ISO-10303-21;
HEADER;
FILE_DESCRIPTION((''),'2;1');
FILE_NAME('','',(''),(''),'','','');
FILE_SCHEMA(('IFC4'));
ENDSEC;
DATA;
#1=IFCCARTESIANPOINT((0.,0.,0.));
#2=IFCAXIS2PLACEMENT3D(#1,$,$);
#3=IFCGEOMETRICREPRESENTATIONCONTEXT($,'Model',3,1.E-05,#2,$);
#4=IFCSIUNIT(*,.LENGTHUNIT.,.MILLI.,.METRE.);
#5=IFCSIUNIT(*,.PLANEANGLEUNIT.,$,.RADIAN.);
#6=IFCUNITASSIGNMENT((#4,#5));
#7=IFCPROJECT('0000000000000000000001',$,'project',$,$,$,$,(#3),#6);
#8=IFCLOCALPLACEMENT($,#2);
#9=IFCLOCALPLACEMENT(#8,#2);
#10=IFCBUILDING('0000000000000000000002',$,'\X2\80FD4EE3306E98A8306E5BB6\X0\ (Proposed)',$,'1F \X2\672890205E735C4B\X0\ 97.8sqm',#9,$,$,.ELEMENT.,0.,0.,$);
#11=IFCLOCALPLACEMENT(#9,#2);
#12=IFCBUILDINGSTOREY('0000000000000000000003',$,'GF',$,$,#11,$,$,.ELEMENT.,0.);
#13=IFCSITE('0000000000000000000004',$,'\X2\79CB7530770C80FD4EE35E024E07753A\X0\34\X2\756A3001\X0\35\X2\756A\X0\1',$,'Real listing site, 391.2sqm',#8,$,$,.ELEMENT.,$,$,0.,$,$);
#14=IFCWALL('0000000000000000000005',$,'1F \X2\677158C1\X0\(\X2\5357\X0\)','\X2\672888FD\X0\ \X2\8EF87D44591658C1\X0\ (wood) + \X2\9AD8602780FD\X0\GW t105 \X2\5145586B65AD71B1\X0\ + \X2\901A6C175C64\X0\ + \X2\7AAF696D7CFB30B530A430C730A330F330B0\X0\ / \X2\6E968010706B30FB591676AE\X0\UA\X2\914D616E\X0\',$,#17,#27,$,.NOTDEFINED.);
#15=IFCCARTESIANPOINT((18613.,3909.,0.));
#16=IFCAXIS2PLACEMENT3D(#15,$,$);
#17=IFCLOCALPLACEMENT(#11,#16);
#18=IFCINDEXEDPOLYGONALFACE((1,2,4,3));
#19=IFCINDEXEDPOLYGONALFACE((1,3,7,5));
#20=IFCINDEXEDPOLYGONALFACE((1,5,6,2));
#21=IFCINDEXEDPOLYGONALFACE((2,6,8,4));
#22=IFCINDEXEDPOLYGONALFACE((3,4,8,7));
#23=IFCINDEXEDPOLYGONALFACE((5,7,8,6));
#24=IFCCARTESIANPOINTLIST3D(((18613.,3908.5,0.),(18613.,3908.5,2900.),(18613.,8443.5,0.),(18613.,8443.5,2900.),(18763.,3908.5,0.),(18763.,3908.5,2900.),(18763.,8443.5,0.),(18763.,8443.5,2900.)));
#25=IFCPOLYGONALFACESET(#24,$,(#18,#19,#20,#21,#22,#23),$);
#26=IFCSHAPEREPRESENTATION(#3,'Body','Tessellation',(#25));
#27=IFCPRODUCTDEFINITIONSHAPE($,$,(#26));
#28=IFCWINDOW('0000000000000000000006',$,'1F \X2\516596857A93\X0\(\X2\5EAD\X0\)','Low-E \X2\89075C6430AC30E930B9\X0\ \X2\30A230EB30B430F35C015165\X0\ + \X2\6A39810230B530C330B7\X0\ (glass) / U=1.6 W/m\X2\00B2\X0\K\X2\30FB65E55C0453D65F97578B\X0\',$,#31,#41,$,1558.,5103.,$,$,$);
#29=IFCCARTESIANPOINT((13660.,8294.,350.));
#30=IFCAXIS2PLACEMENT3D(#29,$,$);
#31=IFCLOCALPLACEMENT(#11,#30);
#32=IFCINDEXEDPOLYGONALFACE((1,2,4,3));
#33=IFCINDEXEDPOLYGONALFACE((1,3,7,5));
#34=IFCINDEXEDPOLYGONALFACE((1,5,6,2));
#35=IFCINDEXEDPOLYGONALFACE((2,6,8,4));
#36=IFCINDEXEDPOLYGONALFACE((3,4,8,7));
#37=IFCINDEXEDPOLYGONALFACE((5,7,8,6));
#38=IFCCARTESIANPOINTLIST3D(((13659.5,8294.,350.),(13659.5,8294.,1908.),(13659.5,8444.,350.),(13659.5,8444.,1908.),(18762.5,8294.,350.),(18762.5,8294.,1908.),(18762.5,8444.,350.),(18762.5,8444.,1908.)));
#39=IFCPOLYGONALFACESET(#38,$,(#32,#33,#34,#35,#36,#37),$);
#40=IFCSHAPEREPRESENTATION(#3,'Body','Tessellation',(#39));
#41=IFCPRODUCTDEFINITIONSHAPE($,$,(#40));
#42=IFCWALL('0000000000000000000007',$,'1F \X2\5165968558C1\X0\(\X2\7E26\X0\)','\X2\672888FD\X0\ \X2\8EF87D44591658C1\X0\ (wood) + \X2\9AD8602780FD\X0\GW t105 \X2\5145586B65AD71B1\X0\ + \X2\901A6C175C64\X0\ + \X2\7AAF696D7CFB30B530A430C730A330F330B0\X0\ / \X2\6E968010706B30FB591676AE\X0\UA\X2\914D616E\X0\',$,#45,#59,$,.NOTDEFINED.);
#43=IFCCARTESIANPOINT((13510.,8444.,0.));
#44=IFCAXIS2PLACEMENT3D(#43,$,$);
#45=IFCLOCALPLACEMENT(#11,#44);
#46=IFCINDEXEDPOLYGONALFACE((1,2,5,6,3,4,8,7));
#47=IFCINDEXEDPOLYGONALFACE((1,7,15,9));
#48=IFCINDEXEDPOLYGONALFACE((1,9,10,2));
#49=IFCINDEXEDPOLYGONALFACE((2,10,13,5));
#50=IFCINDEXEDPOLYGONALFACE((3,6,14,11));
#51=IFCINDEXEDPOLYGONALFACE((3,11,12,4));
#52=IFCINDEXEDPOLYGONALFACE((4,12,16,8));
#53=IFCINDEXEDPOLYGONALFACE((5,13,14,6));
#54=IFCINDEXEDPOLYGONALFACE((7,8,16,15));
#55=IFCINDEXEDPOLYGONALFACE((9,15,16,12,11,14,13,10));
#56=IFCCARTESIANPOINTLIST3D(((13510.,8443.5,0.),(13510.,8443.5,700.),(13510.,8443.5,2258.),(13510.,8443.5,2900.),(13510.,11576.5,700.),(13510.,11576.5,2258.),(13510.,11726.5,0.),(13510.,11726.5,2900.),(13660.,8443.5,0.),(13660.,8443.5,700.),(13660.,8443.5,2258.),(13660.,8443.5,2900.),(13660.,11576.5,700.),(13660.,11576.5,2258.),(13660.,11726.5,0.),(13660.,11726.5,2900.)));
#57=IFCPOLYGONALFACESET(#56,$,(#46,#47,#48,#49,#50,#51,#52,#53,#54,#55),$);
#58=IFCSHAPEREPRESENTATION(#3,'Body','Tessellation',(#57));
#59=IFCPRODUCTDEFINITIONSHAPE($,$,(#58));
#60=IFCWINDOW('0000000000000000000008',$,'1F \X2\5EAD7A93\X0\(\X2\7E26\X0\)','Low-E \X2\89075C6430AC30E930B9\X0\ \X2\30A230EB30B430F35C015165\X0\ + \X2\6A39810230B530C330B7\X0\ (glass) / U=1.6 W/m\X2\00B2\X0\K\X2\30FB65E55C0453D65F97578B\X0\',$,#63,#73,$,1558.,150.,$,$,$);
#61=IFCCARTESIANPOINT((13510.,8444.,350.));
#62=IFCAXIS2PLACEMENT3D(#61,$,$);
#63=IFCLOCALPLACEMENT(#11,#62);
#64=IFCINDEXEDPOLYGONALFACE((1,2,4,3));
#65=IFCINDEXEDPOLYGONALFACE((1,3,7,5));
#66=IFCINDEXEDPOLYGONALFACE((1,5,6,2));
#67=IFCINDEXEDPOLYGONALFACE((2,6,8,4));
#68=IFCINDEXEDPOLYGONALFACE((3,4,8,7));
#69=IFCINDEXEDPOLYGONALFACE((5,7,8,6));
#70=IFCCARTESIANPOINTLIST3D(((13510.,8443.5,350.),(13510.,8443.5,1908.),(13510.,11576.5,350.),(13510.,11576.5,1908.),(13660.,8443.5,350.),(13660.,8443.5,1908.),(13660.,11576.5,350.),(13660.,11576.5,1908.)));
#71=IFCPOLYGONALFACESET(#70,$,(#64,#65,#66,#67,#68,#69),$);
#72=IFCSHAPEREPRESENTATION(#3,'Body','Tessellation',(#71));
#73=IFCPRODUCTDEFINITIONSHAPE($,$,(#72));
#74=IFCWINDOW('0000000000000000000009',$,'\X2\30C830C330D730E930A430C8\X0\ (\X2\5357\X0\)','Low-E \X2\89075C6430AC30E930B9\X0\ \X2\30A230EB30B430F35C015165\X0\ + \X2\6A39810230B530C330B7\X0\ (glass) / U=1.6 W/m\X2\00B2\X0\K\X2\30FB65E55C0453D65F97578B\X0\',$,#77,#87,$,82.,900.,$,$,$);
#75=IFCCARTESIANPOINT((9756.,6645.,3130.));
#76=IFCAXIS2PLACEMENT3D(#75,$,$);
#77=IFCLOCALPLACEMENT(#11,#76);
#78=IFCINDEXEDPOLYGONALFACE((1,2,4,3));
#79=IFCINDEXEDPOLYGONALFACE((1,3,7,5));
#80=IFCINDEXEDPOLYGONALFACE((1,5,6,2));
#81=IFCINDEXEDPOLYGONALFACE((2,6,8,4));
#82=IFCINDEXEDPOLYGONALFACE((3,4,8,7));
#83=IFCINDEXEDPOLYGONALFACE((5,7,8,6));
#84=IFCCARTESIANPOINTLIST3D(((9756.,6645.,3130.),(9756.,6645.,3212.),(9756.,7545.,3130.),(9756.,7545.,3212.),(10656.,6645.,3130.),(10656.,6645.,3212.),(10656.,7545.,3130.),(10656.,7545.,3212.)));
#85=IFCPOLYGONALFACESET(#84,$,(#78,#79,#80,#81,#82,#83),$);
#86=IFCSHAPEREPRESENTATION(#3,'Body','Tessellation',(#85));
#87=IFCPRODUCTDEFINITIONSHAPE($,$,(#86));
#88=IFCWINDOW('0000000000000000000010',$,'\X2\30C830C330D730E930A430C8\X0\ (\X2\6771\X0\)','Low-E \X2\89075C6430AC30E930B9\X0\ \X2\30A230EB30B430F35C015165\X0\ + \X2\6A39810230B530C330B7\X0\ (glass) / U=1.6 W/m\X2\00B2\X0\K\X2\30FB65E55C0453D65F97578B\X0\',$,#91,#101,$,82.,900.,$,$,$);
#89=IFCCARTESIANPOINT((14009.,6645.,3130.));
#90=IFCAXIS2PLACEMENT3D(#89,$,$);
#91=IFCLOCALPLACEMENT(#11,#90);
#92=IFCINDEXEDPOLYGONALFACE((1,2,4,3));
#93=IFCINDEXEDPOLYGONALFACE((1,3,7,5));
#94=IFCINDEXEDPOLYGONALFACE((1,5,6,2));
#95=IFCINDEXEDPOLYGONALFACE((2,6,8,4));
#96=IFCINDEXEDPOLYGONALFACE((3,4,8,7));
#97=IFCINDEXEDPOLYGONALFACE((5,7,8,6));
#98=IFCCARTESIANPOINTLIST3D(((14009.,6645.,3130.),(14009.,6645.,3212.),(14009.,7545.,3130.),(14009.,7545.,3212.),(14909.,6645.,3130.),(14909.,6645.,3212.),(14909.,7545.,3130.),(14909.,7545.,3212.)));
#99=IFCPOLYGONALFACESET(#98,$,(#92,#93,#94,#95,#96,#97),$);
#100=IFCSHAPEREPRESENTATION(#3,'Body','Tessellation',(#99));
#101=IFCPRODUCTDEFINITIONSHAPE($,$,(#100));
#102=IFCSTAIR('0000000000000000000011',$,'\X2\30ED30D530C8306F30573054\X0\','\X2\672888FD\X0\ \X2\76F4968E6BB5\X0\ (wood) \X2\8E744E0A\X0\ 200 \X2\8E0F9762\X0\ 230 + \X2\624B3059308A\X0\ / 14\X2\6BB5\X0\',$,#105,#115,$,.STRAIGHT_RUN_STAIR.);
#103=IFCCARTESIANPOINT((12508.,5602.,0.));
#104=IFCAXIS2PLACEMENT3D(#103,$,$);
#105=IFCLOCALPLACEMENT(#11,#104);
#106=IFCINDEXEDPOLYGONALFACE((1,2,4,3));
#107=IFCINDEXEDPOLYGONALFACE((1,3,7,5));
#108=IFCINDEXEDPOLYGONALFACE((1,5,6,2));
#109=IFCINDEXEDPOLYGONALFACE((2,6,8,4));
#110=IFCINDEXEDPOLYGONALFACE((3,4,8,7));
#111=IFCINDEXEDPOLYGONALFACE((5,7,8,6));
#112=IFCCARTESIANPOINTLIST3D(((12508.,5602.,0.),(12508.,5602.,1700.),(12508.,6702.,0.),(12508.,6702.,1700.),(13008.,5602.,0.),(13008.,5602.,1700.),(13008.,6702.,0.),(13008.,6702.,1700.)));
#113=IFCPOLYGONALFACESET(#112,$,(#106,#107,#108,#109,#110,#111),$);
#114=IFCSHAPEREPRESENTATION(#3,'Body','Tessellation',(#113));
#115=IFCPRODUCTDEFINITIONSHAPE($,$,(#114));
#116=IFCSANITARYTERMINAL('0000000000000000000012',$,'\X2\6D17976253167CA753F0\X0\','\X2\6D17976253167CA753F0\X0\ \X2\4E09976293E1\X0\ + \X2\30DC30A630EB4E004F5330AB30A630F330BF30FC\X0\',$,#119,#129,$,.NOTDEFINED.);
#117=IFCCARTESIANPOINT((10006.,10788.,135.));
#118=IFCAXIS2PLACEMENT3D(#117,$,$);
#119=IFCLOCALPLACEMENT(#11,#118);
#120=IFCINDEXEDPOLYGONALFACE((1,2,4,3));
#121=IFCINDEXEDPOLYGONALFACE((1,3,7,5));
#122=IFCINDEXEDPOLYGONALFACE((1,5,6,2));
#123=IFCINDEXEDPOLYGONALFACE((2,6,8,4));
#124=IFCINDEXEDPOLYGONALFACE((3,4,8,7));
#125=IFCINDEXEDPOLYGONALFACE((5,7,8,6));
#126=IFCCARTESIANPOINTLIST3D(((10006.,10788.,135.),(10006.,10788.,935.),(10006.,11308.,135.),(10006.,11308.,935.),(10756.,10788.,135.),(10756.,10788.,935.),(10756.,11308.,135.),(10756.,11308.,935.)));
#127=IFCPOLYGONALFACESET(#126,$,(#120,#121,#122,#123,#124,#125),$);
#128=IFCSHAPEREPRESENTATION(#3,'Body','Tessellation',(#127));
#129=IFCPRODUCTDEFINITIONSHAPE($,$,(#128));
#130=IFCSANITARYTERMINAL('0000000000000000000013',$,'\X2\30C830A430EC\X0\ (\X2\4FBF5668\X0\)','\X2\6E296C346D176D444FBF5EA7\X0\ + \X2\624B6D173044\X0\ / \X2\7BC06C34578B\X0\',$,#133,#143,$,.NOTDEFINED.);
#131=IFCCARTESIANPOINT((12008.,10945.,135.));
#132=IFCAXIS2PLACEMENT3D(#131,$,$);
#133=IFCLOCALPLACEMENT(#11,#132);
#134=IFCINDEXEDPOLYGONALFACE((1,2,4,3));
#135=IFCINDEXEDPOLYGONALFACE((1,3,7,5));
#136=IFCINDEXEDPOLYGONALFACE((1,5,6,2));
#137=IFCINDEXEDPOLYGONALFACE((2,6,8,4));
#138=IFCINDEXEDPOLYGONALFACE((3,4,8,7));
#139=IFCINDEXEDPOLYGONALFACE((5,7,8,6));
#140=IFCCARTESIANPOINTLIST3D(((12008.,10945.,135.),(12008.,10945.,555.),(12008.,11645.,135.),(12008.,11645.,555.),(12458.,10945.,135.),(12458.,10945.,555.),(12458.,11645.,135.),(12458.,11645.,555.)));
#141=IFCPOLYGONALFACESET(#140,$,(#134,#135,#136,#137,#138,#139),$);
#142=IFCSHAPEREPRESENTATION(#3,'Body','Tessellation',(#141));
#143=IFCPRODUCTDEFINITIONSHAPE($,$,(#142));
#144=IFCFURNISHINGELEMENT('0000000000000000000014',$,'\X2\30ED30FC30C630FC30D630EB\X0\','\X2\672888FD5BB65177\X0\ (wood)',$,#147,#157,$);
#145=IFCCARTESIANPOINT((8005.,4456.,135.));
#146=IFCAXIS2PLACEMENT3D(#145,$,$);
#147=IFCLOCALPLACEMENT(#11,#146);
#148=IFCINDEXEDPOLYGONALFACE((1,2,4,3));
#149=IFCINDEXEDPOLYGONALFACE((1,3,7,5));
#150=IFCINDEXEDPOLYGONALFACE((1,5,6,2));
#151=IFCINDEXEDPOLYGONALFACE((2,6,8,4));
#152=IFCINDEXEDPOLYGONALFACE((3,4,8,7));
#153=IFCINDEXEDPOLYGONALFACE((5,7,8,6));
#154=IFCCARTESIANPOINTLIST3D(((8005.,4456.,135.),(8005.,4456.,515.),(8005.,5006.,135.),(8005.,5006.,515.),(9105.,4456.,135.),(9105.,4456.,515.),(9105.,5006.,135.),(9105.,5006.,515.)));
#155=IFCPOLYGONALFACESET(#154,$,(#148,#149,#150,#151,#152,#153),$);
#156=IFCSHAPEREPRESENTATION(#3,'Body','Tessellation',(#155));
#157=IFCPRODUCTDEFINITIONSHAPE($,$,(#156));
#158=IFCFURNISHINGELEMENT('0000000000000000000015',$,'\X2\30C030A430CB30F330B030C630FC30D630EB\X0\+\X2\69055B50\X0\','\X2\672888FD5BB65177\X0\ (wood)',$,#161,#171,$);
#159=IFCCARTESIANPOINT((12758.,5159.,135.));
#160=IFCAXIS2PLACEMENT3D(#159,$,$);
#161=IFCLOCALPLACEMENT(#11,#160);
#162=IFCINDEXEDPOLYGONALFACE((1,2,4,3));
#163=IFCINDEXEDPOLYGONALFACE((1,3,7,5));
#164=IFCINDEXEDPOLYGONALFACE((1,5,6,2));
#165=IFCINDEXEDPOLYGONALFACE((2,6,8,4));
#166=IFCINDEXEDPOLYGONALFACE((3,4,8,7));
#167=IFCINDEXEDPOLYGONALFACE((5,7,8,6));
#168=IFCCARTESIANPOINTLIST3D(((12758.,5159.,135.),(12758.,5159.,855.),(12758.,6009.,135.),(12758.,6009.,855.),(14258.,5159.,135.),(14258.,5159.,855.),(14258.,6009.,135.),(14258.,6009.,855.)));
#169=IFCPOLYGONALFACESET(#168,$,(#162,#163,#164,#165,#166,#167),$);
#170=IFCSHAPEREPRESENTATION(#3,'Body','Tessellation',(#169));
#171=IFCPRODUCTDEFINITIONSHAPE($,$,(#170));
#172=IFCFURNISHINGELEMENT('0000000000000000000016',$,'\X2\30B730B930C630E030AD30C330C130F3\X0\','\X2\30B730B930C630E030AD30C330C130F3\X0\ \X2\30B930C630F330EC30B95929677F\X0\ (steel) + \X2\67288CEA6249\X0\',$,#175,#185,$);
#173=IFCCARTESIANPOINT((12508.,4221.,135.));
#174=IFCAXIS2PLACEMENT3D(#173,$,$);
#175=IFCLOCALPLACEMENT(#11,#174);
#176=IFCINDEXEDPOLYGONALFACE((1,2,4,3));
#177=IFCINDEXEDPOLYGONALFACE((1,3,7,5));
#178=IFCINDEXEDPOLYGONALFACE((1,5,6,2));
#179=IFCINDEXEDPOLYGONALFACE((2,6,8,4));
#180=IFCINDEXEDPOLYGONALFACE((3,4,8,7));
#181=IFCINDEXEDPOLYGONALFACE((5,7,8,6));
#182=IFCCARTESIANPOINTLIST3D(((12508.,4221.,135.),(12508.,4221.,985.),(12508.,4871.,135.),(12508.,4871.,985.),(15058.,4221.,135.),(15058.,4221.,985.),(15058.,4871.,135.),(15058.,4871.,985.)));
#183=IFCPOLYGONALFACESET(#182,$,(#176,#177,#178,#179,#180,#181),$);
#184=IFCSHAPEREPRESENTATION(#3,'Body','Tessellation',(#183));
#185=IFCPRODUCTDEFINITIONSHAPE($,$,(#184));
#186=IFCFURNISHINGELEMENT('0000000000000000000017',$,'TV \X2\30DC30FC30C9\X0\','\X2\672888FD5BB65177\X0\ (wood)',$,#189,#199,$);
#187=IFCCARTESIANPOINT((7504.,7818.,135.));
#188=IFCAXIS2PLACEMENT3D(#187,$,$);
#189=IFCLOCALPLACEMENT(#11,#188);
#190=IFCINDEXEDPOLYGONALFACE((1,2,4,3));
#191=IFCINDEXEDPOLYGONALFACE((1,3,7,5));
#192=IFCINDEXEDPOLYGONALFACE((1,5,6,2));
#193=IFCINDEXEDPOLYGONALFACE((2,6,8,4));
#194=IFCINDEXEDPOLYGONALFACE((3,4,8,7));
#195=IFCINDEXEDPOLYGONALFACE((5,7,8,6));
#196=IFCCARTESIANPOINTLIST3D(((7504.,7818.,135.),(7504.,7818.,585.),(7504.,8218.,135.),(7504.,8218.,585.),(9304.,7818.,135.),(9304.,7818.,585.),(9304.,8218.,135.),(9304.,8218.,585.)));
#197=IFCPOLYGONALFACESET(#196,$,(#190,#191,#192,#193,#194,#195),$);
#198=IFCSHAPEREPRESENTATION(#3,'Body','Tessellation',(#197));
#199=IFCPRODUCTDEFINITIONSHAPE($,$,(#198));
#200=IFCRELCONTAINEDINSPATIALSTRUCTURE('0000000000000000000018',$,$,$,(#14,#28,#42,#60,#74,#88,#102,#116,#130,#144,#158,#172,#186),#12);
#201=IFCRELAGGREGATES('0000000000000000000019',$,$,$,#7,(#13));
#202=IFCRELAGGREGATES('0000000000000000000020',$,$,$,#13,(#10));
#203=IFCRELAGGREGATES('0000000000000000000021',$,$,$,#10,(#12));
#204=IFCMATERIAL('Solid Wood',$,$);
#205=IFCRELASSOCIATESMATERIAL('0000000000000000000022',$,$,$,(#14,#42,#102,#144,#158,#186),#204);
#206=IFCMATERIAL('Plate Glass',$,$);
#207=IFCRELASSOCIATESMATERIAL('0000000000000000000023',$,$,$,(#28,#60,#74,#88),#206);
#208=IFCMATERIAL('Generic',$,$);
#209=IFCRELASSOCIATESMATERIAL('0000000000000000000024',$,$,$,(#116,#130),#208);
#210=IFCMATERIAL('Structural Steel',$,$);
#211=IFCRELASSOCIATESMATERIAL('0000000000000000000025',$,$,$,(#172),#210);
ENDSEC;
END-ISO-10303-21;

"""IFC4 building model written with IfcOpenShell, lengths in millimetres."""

from ifc_helpers import new_model, si_unit, frame, frame_2d, origin, place, context, project, spatial, rectangle, extrude, material, element, fill, save


model = new_model("IFC4")

# Units and contexts
model_context = context("Model", 3, precision=1e-05, world=origin())
ifc_project = project(units=[si_unit("LENGTHUNIT", "METRE", prefix="MILLI"), si_unit("PLANEANGLEUNIT", "RADIAN")], contexts=[model_context])

# Site, building, storey
site_placement = place(None, origin())
site = spatial("IfcSite", under=ifc_project, at=site_placement, Name="秋田県能代市万町34番、35番1", ObjectType="Real listing site, 391.2sqm", CompositionType="ELEMENT", RefElevation=0.0)
building_placement = place(site_placement, origin())
building = spatial("IfcBuilding", under=site, at=building_placement, Name="能代の風の家 (Proposed)", ObjectType="1F 木造平屋 97.8sqm", CompositionType="ELEMENT", ElevationOfRefHeight=0.0, ElevationOfTerrain=0.0)
storey_placement = place(building_placement, origin())
storey = spatial("IfcBuildingStorey", under=building, at=storey_placement, Name="GF", CompositionType="ELEMENT", Elevation=0.0)

# Shared definitions
ifc_material_1 = material(Name="Solid Wood")

# Wall, opening, window
wall_1_placement = place(storey_placement, frame((18613.0, 3909.0, 0.0)))
wall_1 = element("IfcWall", 1, at=wall_1_placement, inside=storey, material=ifc_material_1, Name="1F 東壁(南)", Description="木製 軸組外壁 (wood) + 高性能GW t105 充填断熱 + 通気層 + 窯業系サイディング / 準耐火・外皮UA配慮", PredefinedType="NOTDEFINED", context=model_context, shape_type="SweptSolid", body=[
    extrude(rectangle(XDim=150.0, YDim=4535.0, at=frame_2d((75.0, 2267.0))), frame((18613.0, 3909.0, 0.0)), (0.0, 0.0, 1.0), 2900.0),
])
opening_1_placement = place(storey_placement, frame((13660.0, 8294.0, 350.0)))
opening_1 = element("IfcOpeningElement", 2, at=opening_1_placement, cuts=wall_1, PredefinedType="NOTDEFINED", context=model_context, shape_type="SweptSolid", body=[
    extrude(rectangle(XDim=5103.0, YDim=150.0, at=frame_2d((2551.0, 75.0))), frame((13660.0, 8294.0, 350.0)), (0.0, 0.0, 1.0), 1558.0),
])
ifc_material_2 = material(Name="Plate Glass")
window_1_placement = place(storey_placement, frame((13660.0, 8294.0, 350.0)))
window_1 = element("IfcWindow", 3, at=window_1_placement, inside=storey, material=ifc_material_2, Name="1F 入隅窓(庭)", Description="Low-E 複層ガラス アルゴン封入 + 樹脂サッシ (glass) / U=1.6 W/m²K・日射取得型", OverallHeight=1558.0, OverallWidth=5103.0, context=model_context, shape_type="SweptSolid", body=[
    extrude(rectangle(XDim=5103.0, YDim=150.0, at=frame_2d((2551.0, 75.0))), frame((13660.0, 8294.0, 350.0)), (0.0, 0.0, 1.0), 1558.0),
])
fill(opening_1, window_1)

# Wall, opening, window
wall_2_placement = place(storey_placement, frame((13510.0, 8444.0, 0.0)))
wall_2 = element("IfcWall", 4, at=wall_2_placement, inside=storey, material=ifc_material_1, Name="1F 入隅壁(縦)", Description="木製 軸組外壁 (wood) + 高性能GW t105 充填断熱 + 通気層 + 窯業系サイディング / 準耐火・外皮UA配慮", PredefinedType="NOTDEFINED", context=model_context, shape_type="SweptSolid", body=[
    extrude(rectangle(XDim=150.0, YDim=3283.0, at=frame_2d((75.0, 1641.0))), frame((13510.0, 8444.0, 0.0)), (0.0, 0.0, 1.0), 2900.0),
])
opening_2_placement = place(storey_placement, frame((13510.0, 8444.0, 350.0)))
opening_2 = element("IfcOpeningElement", 5, at=opening_2_placement, cuts=wall_2, PredefinedType="NOTDEFINED", context=model_context, shape_type="SweptSolid", body=[
    extrude(rectangle(XDim=150.0, YDim=3133.0, at=frame_2d((75.0, 1566.0))), frame((13510.0, 8444.0, 350.0)), (0.0, 0.0, 1.0), 1558.0),
])
window_2_placement = place(storey_placement, frame((13510.0, 8444.0, 350.0)))
window_2 = element("IfcWindow", 6, at=window_2_placement, inside=storey, material=ifc_material_2, Name="1F 庭窓(縦)", Description="Low-E 複層ガラス アルゴン封入 + 樹脂サッシ (glass) / U=1.6 W/m²K・日射取得型", OverallHeight=1558.0, OverallWidth=150.0, context=model_context, shape_type="SweptSolid", body=[
    extrude(rectangle(XDim=150.0, YDim=3133.0, at=frame_2d((75.0, 1566.0))), frame((13510.0, 8444.0, 350.0)), (0.0, 0.0, 1.0), 1558.0),
])
fill(opening_2, window_2)

# Windows
window_3_placement = place(storey_placement, frame((9756.0, 6645.0, 3130.0)))
element("IfcWindow", 7, at=window_3_placement, inside=storey, material=ifc_material_2, Name="トップライト (南)", Description="Low-E 複層ガラス アルゴン封入 + 樹脂サッシ (glass) / U=1.6 W/m²K・日射取得型", OverallHeight=82.0, OverallWidth=900.0, context=model_context, shape_type="SweptSolid", body=[
    extrude(rectangle(XDim=900.0, YDim=900.0, at=frame_2d((450.0, 450.0))), frame((9756.0, 6645.0, 3130.0)), (0.0, 0.0, 1.0), 82.0),
])
window_4_placement = place(storey_placement, frame((14009.0, 6645.0, 3130.0)))
element("IfcWindow", 8, at=window_4_placement, inside=storey, material=ifc_material_2, Name="トップライト (東)", Description="Low-E 複層ガラス アルゴン封入 + 樹脂サッシ (glass) / U=1.6 W/m²K・日射取得型", OverallHeight=82.0, OverallWidth=900.0, context=model_context, shape_type="SweptSolid", body=[
    extrude(rectangle(XDim=900.0, YDim=900.0, at=frame_2d((450.0, 450.0))), frame((14009.0, 6645.0, 3130.0)), (0.0, 0.0, 1.0), 82.0),
])

# Stair
stair_placement = place(storey_placement, frame((12508.0, 5602.0, 0.0)))
element("IfcStair", 9, at=stair_placement, inside=storey, material=ifc_material_1, Name="ロフトはしご", Description="木製 直階段 (wood) 蹴上 200 踏面 230 + 手すり / 14段", PredefinedType="STRAIGHT_RUN_STAIR", context=model_context, shape_type="SweptSolid", body=[
    extrude(rectangle(XDim=500.0, YDim=1100.0, at=frame_2d((250.0, 550.0))), frame((12508.0, 5602.0, 0.0)), (0.0, 0.0, 1.0), 1700.0),
])

# Sanitary terminals
ifc_material_3 = material(Name="Generic")
sanitary_terminal_1_placement = place(storey_placement, frame((10006.0, 10788.0, 135.0)))
element("IfcSanitaryTerminal", 10, at=sanitary_terminal_1_placement, inside=storey, material=ifc_material_3, Name="洗面化粧台", Description="洗面化粧台 三面鏡 + ボウル一体カウンター", PredefinedType="NOTDEFINED", context=model_context, shape_type="SweptSolid", body=[
    extrude(rectangle(XDim=750.0, YDim=520.0, at=frame_2d((375.0, 260.0))), frame((10006.0, 10788.0, 135.0)), (0.0, 0.0, 1.0), 800.0),
])
sanitary_terminal_2_placement = place(storey_placement, frame((12008.0, 10945.0, 135.0)))
element("IfcSanitaryTerminal", 11, at=sanitary_terminal_2_placement, inside=storey, material=ifc_material_3, Name="トイレ (便器)", Description="温水洗浄便座 + 手洗い / 節水型", PredefinedType="NOTDEFINED", context=model_context, shape_type="SweptSolid", body=[
    extrude(rectangle(XDim=450.0, YDim=700.0, at=frame_2d((225.0, 350.0))), frame((12008.0, 10945.0, 135.0)), (0.0, 0.0, 1.0), 420.0),
])

# Furnishing elements
furnishing_1_placement = place(storey_placement, frame((8005.0, 4456.0, 135.0)))
element("IfcFurnishingElement", 12, at=furnishing_1_placement, inside=storey, material=ifc_material_1, Name="ローテーブル", Description="木製家具 (wood)", context=model_context, shape_type="SweptSolid", body=[
    extrude(rectangle(XDim=1100.0, YDim=550.0, at=frame_2d((550.0, 275.0))), frame((8005.0, 4456.0, 135.0)), (0.0, 0.0, 1.0), 380.0),
])
furnishing_2_placement = place(storey_placement, frame((12758.0, 5159.0, 135.0)))
element("IfcFurnishingElement", 13, at=furnishing_2_placement, inside=storey, material=ifc_material_1, Name="ダイニングテーブル+椅子", Description="木製家具 (wood)", context=model_context, shape_type="SweptSolid", body=[
    extrude(rectangle(XDim=1500.0, YDim=850.0, at=frame_2d((750.0, 425.0))), frame((12758.0, 5159.0, 135.0)), (0.0, 0.0, 1.0), 720.0),
])
ifc_material_4 = material(Name="Structural Steel")
furnishing_3_placement = place(storey_placement, frame((12508.0, 4221.0, 135.0)))
element("IfcFurnishingElement", 14, at=furnishing_3_placement, inside=storey, material=ifc_material_4, Name="システムキッチン", Description="システムキッチン ステンレス天板 (steel) + 木質扉", context=model_context, shape_type="SweptSolid", body=[
    extrude(rectangle(XDim=2550.0, YDim=650.0, at=frame_2d((1275.0, 325.0))), frame((12508.0, 4221.0, 135.0)), (0.0, 0.0, 1.0), 850.0),
])
furnishing_4_placement = place(storey_placement, frame((7504.0, 7818.0, 135.0)))
element("IfcFurnishingElement", 15, at=furnishing_4_placement, inside=storey, material=ifc_material_1, Name="TV ボード", Description="木製家具 (wood)", context=model_context, shape_type="SweptSolid", body=[
    extrude(rectangle(XDim=1800.0, YDim=400.0, at=frame_2d((900.0, 200.0))), frame((7504.0, 7818.0, 135.0)), (0.0, 0.0, 1.0), 450.0),
])

save(model, "model.ifc")
